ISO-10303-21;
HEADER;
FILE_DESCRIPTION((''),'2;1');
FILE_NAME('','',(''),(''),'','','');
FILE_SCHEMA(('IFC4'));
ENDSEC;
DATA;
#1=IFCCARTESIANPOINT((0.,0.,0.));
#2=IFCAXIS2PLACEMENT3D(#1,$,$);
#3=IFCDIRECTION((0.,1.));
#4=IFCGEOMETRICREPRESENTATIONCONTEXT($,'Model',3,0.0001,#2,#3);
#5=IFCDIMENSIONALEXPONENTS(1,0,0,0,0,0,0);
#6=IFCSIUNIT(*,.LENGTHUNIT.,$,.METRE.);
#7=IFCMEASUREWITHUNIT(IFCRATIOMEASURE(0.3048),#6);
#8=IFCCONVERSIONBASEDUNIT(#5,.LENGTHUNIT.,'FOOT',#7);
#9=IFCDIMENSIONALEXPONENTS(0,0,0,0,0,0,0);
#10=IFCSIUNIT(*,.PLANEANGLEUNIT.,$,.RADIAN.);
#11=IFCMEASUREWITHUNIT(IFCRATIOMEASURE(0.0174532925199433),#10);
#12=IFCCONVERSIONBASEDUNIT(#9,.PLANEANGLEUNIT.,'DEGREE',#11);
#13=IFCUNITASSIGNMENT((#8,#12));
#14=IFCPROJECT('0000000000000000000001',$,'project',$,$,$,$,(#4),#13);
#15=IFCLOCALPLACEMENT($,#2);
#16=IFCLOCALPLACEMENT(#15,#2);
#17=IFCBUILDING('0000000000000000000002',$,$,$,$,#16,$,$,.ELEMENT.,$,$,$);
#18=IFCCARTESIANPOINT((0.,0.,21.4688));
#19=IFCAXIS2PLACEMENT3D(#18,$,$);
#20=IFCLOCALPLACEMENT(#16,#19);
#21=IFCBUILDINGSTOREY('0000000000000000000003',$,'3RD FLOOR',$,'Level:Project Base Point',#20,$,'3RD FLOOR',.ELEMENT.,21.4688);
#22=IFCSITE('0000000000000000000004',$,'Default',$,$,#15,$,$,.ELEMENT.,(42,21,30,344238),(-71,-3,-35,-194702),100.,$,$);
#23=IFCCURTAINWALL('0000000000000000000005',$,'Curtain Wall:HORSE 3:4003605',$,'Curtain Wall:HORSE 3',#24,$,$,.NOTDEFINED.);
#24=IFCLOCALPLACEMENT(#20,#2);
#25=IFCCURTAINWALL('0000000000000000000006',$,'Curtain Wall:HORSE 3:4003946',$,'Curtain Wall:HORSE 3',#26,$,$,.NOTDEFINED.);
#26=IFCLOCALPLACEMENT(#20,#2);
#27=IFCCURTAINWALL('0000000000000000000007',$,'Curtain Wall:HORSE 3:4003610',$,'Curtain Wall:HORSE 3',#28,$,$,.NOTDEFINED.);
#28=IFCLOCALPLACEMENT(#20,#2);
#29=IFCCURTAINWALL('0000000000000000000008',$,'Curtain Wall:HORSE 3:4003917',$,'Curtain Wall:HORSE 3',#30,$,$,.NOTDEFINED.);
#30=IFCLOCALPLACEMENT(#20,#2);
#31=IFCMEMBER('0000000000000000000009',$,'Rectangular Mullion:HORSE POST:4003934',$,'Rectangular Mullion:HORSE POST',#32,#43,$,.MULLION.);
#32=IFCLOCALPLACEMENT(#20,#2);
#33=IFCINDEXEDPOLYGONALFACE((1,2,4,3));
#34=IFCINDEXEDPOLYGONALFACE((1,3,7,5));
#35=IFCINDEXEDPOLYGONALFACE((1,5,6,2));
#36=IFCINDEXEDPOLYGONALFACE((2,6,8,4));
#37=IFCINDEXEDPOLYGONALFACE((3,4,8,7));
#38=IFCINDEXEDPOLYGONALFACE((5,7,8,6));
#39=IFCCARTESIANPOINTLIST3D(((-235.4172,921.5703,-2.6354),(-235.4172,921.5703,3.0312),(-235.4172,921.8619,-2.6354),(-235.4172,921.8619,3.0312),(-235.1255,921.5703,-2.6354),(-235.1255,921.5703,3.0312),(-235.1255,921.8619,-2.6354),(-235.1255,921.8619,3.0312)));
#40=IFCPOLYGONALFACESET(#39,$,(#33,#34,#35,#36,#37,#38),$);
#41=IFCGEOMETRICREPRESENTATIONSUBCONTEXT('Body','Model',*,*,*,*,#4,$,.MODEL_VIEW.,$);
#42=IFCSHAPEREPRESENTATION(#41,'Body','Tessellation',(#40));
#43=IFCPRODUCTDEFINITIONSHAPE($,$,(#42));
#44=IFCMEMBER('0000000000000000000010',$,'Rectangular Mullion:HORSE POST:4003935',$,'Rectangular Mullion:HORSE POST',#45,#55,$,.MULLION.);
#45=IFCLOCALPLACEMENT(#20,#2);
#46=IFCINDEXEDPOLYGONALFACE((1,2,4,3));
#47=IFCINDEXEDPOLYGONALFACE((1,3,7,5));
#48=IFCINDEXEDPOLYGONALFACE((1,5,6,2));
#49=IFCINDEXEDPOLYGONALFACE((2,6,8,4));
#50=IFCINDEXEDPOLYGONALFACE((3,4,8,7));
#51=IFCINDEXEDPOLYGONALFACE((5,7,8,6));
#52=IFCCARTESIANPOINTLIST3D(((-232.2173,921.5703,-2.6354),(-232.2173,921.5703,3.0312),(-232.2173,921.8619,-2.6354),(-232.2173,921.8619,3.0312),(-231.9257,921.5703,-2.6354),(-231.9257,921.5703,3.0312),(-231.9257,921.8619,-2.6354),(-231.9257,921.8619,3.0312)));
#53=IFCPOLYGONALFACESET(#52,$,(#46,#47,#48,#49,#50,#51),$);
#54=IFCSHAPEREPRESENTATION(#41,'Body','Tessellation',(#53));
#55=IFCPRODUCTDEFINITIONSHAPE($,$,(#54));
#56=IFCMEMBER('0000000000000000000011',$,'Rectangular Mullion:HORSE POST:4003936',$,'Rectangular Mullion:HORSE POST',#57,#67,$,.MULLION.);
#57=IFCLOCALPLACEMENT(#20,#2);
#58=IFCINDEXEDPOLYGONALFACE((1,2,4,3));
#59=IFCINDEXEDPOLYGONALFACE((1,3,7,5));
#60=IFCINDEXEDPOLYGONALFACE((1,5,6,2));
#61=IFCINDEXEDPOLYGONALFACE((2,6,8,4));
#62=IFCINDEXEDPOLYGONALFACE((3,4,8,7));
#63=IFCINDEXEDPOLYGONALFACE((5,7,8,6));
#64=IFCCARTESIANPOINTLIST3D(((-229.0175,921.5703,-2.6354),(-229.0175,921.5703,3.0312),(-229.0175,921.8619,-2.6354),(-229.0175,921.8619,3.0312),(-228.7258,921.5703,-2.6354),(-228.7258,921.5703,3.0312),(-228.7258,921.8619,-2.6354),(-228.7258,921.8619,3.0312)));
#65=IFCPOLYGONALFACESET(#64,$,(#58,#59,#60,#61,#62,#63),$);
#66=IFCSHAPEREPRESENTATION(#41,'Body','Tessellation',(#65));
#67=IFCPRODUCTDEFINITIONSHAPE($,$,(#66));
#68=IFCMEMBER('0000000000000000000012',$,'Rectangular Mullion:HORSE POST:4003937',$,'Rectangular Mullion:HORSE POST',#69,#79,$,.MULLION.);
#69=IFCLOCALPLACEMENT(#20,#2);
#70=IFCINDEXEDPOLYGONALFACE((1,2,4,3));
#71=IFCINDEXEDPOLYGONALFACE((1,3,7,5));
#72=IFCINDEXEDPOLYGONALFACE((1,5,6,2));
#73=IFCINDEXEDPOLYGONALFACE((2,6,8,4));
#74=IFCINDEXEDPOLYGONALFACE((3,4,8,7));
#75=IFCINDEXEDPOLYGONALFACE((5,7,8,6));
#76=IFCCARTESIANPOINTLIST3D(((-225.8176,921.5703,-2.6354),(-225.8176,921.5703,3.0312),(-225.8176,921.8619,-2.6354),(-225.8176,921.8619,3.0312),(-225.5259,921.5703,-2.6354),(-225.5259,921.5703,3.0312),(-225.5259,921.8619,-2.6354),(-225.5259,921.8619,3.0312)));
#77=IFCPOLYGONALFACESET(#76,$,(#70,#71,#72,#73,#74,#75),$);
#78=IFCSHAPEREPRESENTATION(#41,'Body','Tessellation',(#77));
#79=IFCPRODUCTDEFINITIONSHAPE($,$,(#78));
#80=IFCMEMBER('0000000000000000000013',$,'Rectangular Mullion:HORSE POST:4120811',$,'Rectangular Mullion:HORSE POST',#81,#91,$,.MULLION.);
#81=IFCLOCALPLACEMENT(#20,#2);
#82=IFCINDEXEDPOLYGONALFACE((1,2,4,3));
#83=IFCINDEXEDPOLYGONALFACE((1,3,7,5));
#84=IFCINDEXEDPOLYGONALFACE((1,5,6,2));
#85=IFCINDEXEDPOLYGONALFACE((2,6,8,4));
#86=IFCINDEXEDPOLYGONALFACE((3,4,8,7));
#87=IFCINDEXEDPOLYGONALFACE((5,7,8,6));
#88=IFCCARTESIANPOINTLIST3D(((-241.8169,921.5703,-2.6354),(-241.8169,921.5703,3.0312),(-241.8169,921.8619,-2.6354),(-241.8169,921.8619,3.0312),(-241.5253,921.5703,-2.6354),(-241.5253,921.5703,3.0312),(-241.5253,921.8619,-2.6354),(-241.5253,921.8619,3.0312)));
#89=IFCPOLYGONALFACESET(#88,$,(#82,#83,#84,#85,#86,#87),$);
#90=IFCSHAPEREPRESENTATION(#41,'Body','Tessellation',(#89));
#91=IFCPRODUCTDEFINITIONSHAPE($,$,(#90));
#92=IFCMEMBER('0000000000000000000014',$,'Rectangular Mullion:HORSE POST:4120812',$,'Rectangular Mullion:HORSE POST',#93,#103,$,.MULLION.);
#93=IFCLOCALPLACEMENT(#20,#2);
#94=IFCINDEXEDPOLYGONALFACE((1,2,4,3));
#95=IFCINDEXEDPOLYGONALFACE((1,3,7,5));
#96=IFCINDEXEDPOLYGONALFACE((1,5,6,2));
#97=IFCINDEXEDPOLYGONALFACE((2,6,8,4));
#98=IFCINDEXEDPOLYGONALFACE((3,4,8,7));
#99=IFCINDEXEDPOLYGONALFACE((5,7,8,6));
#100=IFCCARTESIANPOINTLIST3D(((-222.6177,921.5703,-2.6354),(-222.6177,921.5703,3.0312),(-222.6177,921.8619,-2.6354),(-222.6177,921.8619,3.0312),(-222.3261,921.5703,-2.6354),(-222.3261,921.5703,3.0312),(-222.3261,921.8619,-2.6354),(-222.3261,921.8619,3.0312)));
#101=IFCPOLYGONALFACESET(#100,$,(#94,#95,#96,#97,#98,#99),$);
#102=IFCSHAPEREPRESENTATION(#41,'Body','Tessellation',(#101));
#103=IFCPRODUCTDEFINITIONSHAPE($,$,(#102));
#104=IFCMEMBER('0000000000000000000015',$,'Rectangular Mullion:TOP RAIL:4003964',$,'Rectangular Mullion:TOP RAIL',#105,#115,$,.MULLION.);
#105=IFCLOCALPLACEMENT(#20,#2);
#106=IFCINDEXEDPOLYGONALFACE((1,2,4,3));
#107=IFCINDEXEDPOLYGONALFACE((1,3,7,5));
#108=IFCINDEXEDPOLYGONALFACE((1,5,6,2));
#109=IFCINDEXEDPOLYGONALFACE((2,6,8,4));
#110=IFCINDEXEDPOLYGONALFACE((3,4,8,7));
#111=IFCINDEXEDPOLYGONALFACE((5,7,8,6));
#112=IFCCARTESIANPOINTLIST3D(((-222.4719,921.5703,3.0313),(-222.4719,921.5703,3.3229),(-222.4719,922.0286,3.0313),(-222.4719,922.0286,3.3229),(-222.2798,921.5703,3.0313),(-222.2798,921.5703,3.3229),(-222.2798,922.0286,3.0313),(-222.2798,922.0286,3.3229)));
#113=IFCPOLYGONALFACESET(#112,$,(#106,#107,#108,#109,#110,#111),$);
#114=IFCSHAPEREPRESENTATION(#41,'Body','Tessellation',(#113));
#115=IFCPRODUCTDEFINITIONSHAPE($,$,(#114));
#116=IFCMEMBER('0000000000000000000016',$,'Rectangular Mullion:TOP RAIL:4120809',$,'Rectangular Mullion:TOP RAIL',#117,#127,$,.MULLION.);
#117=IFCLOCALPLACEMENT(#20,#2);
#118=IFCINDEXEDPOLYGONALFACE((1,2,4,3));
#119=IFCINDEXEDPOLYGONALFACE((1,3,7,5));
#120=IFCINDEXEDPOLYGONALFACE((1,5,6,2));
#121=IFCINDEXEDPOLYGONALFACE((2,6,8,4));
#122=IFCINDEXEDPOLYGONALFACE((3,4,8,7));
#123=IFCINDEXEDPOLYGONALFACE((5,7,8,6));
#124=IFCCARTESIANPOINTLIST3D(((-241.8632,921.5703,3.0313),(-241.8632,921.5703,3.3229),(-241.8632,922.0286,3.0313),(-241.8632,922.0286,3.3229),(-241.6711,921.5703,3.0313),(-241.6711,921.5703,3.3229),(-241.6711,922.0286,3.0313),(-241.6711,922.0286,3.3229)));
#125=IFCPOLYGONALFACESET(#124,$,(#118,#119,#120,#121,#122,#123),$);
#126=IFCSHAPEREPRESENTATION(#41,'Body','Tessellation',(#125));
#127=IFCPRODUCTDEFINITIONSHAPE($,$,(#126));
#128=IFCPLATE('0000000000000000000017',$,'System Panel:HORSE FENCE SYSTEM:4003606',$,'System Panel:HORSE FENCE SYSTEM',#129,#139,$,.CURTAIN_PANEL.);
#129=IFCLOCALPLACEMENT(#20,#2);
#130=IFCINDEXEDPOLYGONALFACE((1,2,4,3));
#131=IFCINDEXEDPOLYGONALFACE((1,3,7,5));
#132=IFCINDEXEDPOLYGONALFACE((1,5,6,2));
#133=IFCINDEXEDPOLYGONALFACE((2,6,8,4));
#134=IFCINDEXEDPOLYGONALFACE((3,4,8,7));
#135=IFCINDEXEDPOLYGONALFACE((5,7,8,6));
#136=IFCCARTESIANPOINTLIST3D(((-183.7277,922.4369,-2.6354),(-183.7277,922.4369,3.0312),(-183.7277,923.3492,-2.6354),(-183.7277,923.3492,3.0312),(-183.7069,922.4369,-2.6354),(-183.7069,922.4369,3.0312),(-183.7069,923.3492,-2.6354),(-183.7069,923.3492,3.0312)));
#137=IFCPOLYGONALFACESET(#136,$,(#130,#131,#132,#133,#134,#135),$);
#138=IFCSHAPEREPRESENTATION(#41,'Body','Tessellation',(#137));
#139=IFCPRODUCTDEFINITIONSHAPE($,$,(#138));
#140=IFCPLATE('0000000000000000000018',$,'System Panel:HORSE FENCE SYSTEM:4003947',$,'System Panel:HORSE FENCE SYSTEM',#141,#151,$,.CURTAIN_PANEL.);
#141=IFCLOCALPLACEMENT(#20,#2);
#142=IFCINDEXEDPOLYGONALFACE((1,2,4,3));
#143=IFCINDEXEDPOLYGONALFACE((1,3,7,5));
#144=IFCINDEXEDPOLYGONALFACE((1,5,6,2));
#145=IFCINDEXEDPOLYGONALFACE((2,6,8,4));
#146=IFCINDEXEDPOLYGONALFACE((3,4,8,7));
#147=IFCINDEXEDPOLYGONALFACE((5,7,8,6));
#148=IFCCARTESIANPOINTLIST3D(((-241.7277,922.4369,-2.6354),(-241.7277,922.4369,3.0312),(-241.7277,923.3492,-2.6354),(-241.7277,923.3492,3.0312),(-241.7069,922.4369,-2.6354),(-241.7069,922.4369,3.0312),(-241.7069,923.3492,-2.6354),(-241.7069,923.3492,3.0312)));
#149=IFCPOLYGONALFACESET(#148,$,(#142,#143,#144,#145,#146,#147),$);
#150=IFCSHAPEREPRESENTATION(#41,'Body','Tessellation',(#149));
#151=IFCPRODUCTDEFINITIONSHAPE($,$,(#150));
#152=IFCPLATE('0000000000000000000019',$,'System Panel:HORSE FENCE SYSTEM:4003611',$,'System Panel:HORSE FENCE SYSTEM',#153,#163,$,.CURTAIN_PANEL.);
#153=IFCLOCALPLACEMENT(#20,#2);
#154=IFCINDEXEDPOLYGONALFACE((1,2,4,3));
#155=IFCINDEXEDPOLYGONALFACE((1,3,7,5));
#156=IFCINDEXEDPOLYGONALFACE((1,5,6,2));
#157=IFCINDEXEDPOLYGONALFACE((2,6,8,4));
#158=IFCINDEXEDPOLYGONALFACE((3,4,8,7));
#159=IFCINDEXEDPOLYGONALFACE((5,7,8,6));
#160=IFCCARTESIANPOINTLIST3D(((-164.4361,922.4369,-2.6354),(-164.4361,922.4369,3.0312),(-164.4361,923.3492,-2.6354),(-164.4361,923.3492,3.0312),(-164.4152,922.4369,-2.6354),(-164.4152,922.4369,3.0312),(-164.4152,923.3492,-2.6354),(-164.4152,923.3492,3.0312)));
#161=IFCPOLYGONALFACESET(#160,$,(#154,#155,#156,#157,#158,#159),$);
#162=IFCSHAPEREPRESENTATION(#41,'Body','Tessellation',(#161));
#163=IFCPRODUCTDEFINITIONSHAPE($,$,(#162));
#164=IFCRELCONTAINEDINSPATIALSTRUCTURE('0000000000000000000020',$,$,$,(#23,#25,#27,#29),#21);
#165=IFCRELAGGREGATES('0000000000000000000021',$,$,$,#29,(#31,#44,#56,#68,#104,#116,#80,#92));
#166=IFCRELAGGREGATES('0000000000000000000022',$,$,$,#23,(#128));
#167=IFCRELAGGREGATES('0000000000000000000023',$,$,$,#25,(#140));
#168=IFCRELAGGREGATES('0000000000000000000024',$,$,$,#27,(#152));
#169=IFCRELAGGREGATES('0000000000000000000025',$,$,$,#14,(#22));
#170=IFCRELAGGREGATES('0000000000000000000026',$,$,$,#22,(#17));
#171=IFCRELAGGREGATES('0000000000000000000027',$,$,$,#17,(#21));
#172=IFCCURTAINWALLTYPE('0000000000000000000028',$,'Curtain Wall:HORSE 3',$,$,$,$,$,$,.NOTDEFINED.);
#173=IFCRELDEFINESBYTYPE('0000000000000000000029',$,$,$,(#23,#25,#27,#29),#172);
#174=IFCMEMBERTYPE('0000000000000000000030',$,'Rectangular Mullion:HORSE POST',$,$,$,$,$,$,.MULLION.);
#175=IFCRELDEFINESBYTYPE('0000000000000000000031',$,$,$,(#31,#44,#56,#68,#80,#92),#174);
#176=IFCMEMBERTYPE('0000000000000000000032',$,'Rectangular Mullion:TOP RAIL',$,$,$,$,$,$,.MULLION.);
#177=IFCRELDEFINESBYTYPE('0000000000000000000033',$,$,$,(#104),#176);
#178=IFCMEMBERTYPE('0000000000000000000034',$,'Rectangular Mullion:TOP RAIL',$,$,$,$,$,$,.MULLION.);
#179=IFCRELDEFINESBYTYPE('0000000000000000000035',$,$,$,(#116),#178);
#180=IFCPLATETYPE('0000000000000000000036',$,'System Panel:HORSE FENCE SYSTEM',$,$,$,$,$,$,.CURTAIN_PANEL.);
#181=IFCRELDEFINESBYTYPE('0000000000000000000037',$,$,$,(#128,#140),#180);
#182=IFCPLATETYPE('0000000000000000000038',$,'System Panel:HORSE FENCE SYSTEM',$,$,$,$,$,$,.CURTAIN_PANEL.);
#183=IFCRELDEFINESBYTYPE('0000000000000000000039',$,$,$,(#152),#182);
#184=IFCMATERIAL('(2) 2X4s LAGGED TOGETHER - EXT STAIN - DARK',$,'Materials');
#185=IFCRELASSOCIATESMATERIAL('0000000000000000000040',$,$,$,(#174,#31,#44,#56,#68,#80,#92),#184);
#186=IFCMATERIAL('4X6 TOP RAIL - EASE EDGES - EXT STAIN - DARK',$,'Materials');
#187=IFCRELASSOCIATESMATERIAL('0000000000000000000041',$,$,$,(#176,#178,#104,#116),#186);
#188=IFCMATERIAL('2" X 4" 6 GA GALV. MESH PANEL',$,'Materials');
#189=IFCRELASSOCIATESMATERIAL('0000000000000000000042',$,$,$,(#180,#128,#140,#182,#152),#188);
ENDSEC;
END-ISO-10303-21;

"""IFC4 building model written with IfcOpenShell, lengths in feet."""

from ifc_helpers import new_model, entity, si_unit, converted_unit, direction, frame, frame_2d, origin, origin_2d_with_axis, place, context, subcontext, project, spatial, rectangle, extrude, source, transform, mapped, material, material_profile, profile_set, profile_usage, type_object, type_shapes, element, aggregate, save


model = new_model("IFC4")

# Units and contexts
model_context = context("Model", 3, precision=0.0001, world=origin(), true_north=direction((0.0, 1.0)))
body_context = subcontext(model_context, "Body", "Model", "MODEL_VIEW")
ifc_project = project(units=[converted_unit("LENGTHUNIT", "FOOT", entity("IfcRatioMeasure", 0.3048), si_unit("LENGTHUNIT", "METRE"), dimensions=[1, 0, 0, 0, 0, 0, 0]), converted_unit("PLANEANGLEUNIT", "DEGREE", entity("IfcRatioMeasure", 0.0174532925199433), si_unit("PLANEANGLEUNIT", "RADIAN"), dimensions=[0, 0, 0, 0, 0, 0, 0])], contexts=[model_context])

# Site, building, storey
site_placement = place(None, origin())
site = spatial("IfcSite", under=ifc_project, at=site_placement, Name="Default", CompositionType="ELEMENT", RefLatitude=(42, 21, 30, 344238), RefLongitude=(-71, -3, -35, -194702), RefElevation=100.0)
building_placement = place(site_placement, origin())
building = spatial("IfcBuilding", under=site, at=building_placement, CompositionType="ELEMENT")
storey_placement = place(building_placement, frame((0.0, 0.0, 21.4688)))
storey = spatial("IfcBuildingStorey", under=building, at=storey_placement, Name="3RD FLOOR", ObjectType="Level:Project Base Point", LongName="3RD FLOOR", CompositionType="ELEMENT", Elevation=21.4688)

# Shared definitions
curtain_wall_type = type_object("IfcCurtainWallType", Name="Curtain Wall:HORSE 3", PredefinedType="NOTDEFINED")
ifc_material_1 = material(Name="(2) 2X4s LAGGED TOGETHER - EXT STAIN - DARK", Category="Materials")
ifc_material_profile_1 = material_profile(ifc_material_1, rectangle(XDim=0.2917, YDim=0.2917, at=frame_2d((0.0, 0.0), x_axis=(1.0, 0.0))), Name="HORSE POST")
ifc_profile_set_1 = profile_set([ifc_material_profile_1], Name="HORSE POST")
ifc_material_2 = material(Name="4X6 TOP RAIL - EASE EDGES - EXT STAIN - DARK", Category="Materials")
ifc_material_profile_2 = material_profile(ifc_material_2, rectangle(XDim=0.4583, YDim=0.2917, at=origin_2d_with_axis()), Name="TOP RAIL")
ifc_profile_set_2 = profile_set([ifc_material_profile_2], Name="TOP RAIL")

# Curtain walls
curtain_wall_1_placement = place(storey_placement, frame((0.0, 0.0, -21.4688)))
curtain_wall_1 = element("IfcCurtainWall", 1, at=curtain_wall_1_placement, inside=storey, type_object=curtain_wall_type, Name="Curtain Wall:HORSE 3:4003605", ObjectType="Curtain Wall:HORSE 3", PredefinedType="NOTDEFINED")
curtain_wall_2_placement = place(storey_placement, frame((0.0, 0.0, -21.4688)))
curtain_wall_2 = element("IfcCurtainWall", 2, at=curtain_wall_2_placement, inside=storey, type_object=curtain_wall_type, Name="Curtain Wall:HORSE 3:4003946", ObjectType="Curtain Wall:HORSE 3", PredefinedType="NOTDEFINED")

# Curtain wall
curtain_wall_3_placement = place(storey_placement, frame((0.0, 0.0, -21.4688)))
curtain_wall_3 = element("IfcCurtainWall", 3, at=curtain_wall_3_placement, inside=storey, type_object=curtain_wall_type, Name="Curtain Wall:HORSE 3:4003610", ObjectType="Curtain Wall:HORSE 3", PredefinedType="NOTDEFINED")

# Curtain wall, members
curtain_wall_4_placement = place(storey_placement, frame((0.0, 0.0, -21.4688)))
curtain_wall_4 = element("IfcCurtainWall", 4, at=curtain_wall_4_placement, inside=storey, type_object=curtain_wall_type, Name="Curtain Wall:HORSE 3:4003917", ObjectType="Curtain Wall:HORSE 3", PredefinedType="NOTDEFINED")
member_type_1 = type_object("IfcMemberType", Name="Rectangular Mullion:HORSE POST", PredefinedType="MULLION", material=ifc_profile_set_1)
shared_shape_1 = source(origin(), body_context, "Body", "SweptSolid", [
    extrude(rectangle(XDim=0.2917, YDim=0.2917, at=origin_2d_with_axis()), frame((0.0, 0.1458, -5.6667), z_axis=(0.0, 0.0, 1.0), x_axis=(0.0, -1.0, 0.0)), (0.0, 0.0, 1.0), 5.6667),
])
type_shapes(member_type_1, [shared_shape_1])
ifc_profile_usage_1 = profile_usage(ifc_profile_set_1)
member_1_placement = place(storey_placement, frame((-235.2714, 921.8619, -2.6354), z_axis=(0.0, 0.0, -1.0), x_axis=(1.0, 0.0, 0.0)))
member_1 = element("IfcMember", 5, at=member_1_placement, type_object=member_type_1, material=ifc_profile_usage_1, Name="Rectangular Mullion:HORSE POST:4003934", ObjectType="Rectangular Mullion:HORSE POST", PredefinedType="MULLION", context=body_context, shape_type="MappedRepresentation", body=[
    mapped(shared_shape_1, transform((0.0, 0.0, 0.0), scale=1.0)),
])
ifc_profile_usage_2 = profile_usage(ifc_profile_set_1)
member_2_placement = place(storey_placement, frame((-232.0715, 921.8619, -2.6354), z_axis=(0.0, 0.0, -1.0), x_axis=(1.0, 0.0, 0.0)))
member_2 = element("IfcMember", 6, at=member_2_placement, type_object=member_type_1, material=ifc_profile_usage_2, Name="Rectangular Mullion:HORSE POST:4003935", ObjectType="Rectangular Mullion:HORSE POST", PredefinedType="MULLION", context=body_context, shape_type="MappedRepresentation", body=[
    mapped(shared_shape_1, transform((0.0, 0.0, 0.0), scale=1.0)),
])
ifc_profile_usage_3 = profile_usage(ifc_profile_set_1)
member_3_placement = place(storey_placement, frame((-228.8716, 921.8619, -2.6354), z_axis=(0.0, 0.0, -1.0), x_axis=(1.0, 0.0, 0.0)))
member_3 = element("IfcMember", 7, at=member_3_placement, type_object=member_type_1, material=ifc_profile_usage_3, Name="Rectangular Mullion:HORSE POST:4003936", ObjectType="Rectangular Mullion:HORSE POST", PredefinedType="MULLION", context=body_context, shape_type="MappedRepresentation", body=[
    mapped(shared_shape_1, transform((0.0, 0.0, 0.0), scale=1.0)),
])
ifc_profile_usage_4 = profile_usage(ifc_profile_set_1)
member_4_placement = place(storey_placement, frame((-225.6718, 921.8619, -2.6354), z_axis=(0.0, 0.0, -1.0), x_axis=(1.0, 0.0, 0.0)))
member_4 = element("IfcMember", 8, at=member_4_placement, type_object=member_type_1, material=ifc_profile_usage_4, Name="Rectangular Mullion:HORSE POST:4003937", ObjectType="Rectangular Mullion:HORSE POST", PredefinedType="MULLION", context=body_context, shape_type="MappedRepresentation", body=[
    mapped(shared_shape_1, transform((0.0, 0.0, 0.0), scale=1.0)),
])
ifc_profile_usage_5 = profile_usage(ifc_profile_set_1)
member_5_placement = place(storey_placement, frame((-241.6711, 921.8619, -2.6354), z_axis=(0.0, 0.0, -1.0), x_axis=(1.0, 0.0, 0.0)))
member_5 = element("IfcMember", 9, at=member_5_placement, type_object=member_type_1, material=ifc_profile_usage_5, Name="Rectangular Mullion:HORSE POST:4120811", ObjectType="Rectangular Mullion:HORSE POST", PredefinedType="MULLION", context=body_context, shape_type="MappedRepresentation", body=[
    mapped(shared_shape_1, transform((0.0, 0.0, 0.0), scale=1.0)),
])
ifc_profile_usage_6 = profile_usage(ifc_profile_set_1)
member_6_placement = place(storey_placement, frame((-222.4719, 921.8619, -2.6354), z_axis=(0.0, 0.0, -1.0), x_axis=(1.0, 0.0, 0.0)))
member_6 = element("IfcMember", 10, at=member_6_placement, type_object=member_type_1, material=ifc_profile_usage_6, Name="Rectangular Mullion:HORSE POST:4120812", ObjectType="Rectangular Mullion:HORSE POST", PredefinedType="MULLION", context=body_context, shape_type="MappedRepresentation", body=[
    mapped(shared_shape_1, transform((0.0, 0.0, 0.0), scale=1.0)),
])
ifc_profile_usage_7 = profile_usage(ifc_profile_set_2)
member_type_2 = type_object("IfcMemberType", Name="Rectangular Mullion:TOP RAIL", PredefinedType="MULLION", material=ifc_profile_set_2)
shared_shape_2 = source(origin(), body_context, "Body", "SweptSolid", [
    extrude(rectangle(XDim=0.4583, YDim=0.2917, at=origin_2d_with_axis()), frame((-0.1458, 0.0625, -0.1921), z_axis=(0.0, 0.0, 1.0), x_axis=(0.0, -1.0, 0.0)), (0.0, 0.0, 1.0), 0.1921),
])
type_shapes(member_type_2, [shared_shape_2])
member_7_placement = place(storey_placement, frame((-222.2798, 921.8619, 3.3229), z_axis=(1.0, 0.0, 0.0), x_axis=(0.0, 0.0, 1.0)))
member_7 = element("IfcMember", 11, at=member_7_placement, type_object=member_type_2, material=ifc_profile_usage_7, Name="Rectangular Mullion:TOP RAIL:4003964", ObjectType="Rectangular Mullion:TOP RAIL", PredefinedType="MULLION", context=body_context, shape_type="MappedRepresentation", body=[
    mapped(shared_shape_2, transform((0.0, 0.0, 0.0), scale=1.0)),
])
ifc_profile_usage_8 = profile_usage(ifc_profile_set_2)
member_type_3 = type_object("IfcMemberType", Name="Rectangular Mullion:TOP RAIL", PredefinedType="MULLION", material=ifc_profile_set_2)
shared_shape_3 = source(origin(), body_context, "Body", "SweptSolid", [
    extrude(rectangle(XDim=0.4583, YDim=0.2917, at=origin_2d_with_axis()), frame((-0.1458, 0.0625, -0.1921), z_axis=(0.0, 0.0, 1.0), x_axis=(0.0, -1.0, 0.0)), (0.0, 0.0, 1.0), 0.1921),
])
type_shapes(member_type_3, [shared_shape_3])
member_8_placement = place(storey_placement, frame((-241.6711, 921.8619, 3.3229), z_axis=(1.0, 0.0, 0.0), x_axis=(0.0, 0.0, 1.0)))
member_8 = element("IfcMember", 12, at=member_8_placement, type_object=member_type_3, material=ifc_profile_usage_8, Name="Rectangular Mullion:TOP RAIL:4120809", ObjectType="Rectangular Mullion:TOP RAIL", PredefinedType="MULLION", context=body_context, shape_type="MappedRepresentation", body=[
    mapped(shared_shape_3, transform((0.0, 0.0, 0.0), scale=1.0)),
])
aggregate(curtain_wall_4, [member_1, member_2, member_3, member_4, member_7, member_8, member_5, member_6])

# Plates
ifc_material_3 = material(Name="2\" X 4\" 6 GA GALV. MESH PANEL", Category="Materials")
plate_type_1 = type_object("IfcPlateType", Name="System Panel:HORSE FENCE SYSTEM", PredefinedType="CURTAIN_PANEL", material=ifc_material_3)
shared_shape_4 = source(origin(), body_context, "Body", "SweptSolid", [
    extrude(rectangle(XDim=0.0208, YDim=0.9123, at=frame_2d((0.0, 0.0), x_axis=(1.0, 0.0))), frame((0.4561, 0.0104, 0.0), z_axis=(0.0, 0.0, 1.0), x_axis=(0.0, 1.0, 0.0)), (0.0, 0.0, 1.0), 5.6667),
])
type_shapes(plate_type_1, [shared_shape_4])
plate_1_placement = place(curtain_wall_1_placement, frame((-183.7277, 923.3492, 18.8333), z_axis=(0.0, 0.0, 1.0), x_axis=(0.0, -1.0, 0.0)))
plate_1 = element("IfcPlate", 13, at=plate_1_placement, type_object=plate_type_1, material=ifc_material_3, Name="System Panel:HORSE FENCE SYSTEM:4003606", ObjectType="System Panel:HORSE FENCE SYSTEM", PredefinedType="CURTAIN_PANEL", context=body_context, shape_type="MappedRepresentation", body=[
    mapped(shared_shape_4, transform((0.0, 0.0, 0.0), scale=1.0)),
])
aggregate(curtain_wall_1, [plate_1])
plate_2_placement = place(curtain_wall_2_placement, frame((-241.7277, 923.3492, 18.8333), z_axis=(0.0, 0.0, 1.0), x_axis=(0.0, -1.0, 0.0)))
plate_2 = element("IfcPlate", 14, at=plate_2_placement, type_object=plate_type_1, material=ifc_material_3, Name="System Panel:HORSE FENCE SYSTEM:4003947", ObjectType="System Panel:HORSE FENCE SYSTEM", PredefinedType="CURTAIN_PANEL", context=body_context, shape_type="MappedRepresentation", body=[
    mapped(shared_shape_4, transform((0.0, 0.0, 0.0), scale=1.0)),
])
aggregate(curtain_wall_2, [plate_2])
plate_type_2 = type_object("IfcPlateType", Name="System Panel:HORSE FENCE SYSTEM", PredefinedType="CURTAIN_PANEL", material=ifc_material_3)
shared_shape_5 = source(origin(), body_context, "Body", "SweptSolid", [
    extrude(rectangle(XDim=0.0208, YDim=0.9123, at=frame_2d((0.0, 0.0), x_axis=(1.0, 0.0))), frame((0.4561, 0.0104, 0.0), z_axis=(0.0, 0.0, 1.0), x_axis=(0.0, 1.0, 0.0)), (0.0, 0.0, 1.0), 5.6667),
])
type_shapes(plate_type_2, [shared_shape_5])
plate_3_placement = place(curtain_wall_3_placement, frame((-164.4361, 923.3492, 18.8333), z_axis=(0.0, 0.0, 1.0), x_axis=(0.0, -1.0, 0.0)))
plate_3 = element("IfcPlate", 15, at=plate_3_placement, type_object=plate_type_2, material=ifc_material_3, Name="System Panel:HORSE FENCE SYSTEM:4003611", ObjectType="System Panel:HORSE FENCE SYSTEM", PredefinedType="CURTAIN_PANEL", context=body_context, shape_type="MappedRepresentation", body=[
    mapped(shared_shape_5, transform((0.0, 0.0, 0.0), scale=1.0)),
])
aggregate(curtain_wall_3, [plate_3])

save(model, "model.ifc")
